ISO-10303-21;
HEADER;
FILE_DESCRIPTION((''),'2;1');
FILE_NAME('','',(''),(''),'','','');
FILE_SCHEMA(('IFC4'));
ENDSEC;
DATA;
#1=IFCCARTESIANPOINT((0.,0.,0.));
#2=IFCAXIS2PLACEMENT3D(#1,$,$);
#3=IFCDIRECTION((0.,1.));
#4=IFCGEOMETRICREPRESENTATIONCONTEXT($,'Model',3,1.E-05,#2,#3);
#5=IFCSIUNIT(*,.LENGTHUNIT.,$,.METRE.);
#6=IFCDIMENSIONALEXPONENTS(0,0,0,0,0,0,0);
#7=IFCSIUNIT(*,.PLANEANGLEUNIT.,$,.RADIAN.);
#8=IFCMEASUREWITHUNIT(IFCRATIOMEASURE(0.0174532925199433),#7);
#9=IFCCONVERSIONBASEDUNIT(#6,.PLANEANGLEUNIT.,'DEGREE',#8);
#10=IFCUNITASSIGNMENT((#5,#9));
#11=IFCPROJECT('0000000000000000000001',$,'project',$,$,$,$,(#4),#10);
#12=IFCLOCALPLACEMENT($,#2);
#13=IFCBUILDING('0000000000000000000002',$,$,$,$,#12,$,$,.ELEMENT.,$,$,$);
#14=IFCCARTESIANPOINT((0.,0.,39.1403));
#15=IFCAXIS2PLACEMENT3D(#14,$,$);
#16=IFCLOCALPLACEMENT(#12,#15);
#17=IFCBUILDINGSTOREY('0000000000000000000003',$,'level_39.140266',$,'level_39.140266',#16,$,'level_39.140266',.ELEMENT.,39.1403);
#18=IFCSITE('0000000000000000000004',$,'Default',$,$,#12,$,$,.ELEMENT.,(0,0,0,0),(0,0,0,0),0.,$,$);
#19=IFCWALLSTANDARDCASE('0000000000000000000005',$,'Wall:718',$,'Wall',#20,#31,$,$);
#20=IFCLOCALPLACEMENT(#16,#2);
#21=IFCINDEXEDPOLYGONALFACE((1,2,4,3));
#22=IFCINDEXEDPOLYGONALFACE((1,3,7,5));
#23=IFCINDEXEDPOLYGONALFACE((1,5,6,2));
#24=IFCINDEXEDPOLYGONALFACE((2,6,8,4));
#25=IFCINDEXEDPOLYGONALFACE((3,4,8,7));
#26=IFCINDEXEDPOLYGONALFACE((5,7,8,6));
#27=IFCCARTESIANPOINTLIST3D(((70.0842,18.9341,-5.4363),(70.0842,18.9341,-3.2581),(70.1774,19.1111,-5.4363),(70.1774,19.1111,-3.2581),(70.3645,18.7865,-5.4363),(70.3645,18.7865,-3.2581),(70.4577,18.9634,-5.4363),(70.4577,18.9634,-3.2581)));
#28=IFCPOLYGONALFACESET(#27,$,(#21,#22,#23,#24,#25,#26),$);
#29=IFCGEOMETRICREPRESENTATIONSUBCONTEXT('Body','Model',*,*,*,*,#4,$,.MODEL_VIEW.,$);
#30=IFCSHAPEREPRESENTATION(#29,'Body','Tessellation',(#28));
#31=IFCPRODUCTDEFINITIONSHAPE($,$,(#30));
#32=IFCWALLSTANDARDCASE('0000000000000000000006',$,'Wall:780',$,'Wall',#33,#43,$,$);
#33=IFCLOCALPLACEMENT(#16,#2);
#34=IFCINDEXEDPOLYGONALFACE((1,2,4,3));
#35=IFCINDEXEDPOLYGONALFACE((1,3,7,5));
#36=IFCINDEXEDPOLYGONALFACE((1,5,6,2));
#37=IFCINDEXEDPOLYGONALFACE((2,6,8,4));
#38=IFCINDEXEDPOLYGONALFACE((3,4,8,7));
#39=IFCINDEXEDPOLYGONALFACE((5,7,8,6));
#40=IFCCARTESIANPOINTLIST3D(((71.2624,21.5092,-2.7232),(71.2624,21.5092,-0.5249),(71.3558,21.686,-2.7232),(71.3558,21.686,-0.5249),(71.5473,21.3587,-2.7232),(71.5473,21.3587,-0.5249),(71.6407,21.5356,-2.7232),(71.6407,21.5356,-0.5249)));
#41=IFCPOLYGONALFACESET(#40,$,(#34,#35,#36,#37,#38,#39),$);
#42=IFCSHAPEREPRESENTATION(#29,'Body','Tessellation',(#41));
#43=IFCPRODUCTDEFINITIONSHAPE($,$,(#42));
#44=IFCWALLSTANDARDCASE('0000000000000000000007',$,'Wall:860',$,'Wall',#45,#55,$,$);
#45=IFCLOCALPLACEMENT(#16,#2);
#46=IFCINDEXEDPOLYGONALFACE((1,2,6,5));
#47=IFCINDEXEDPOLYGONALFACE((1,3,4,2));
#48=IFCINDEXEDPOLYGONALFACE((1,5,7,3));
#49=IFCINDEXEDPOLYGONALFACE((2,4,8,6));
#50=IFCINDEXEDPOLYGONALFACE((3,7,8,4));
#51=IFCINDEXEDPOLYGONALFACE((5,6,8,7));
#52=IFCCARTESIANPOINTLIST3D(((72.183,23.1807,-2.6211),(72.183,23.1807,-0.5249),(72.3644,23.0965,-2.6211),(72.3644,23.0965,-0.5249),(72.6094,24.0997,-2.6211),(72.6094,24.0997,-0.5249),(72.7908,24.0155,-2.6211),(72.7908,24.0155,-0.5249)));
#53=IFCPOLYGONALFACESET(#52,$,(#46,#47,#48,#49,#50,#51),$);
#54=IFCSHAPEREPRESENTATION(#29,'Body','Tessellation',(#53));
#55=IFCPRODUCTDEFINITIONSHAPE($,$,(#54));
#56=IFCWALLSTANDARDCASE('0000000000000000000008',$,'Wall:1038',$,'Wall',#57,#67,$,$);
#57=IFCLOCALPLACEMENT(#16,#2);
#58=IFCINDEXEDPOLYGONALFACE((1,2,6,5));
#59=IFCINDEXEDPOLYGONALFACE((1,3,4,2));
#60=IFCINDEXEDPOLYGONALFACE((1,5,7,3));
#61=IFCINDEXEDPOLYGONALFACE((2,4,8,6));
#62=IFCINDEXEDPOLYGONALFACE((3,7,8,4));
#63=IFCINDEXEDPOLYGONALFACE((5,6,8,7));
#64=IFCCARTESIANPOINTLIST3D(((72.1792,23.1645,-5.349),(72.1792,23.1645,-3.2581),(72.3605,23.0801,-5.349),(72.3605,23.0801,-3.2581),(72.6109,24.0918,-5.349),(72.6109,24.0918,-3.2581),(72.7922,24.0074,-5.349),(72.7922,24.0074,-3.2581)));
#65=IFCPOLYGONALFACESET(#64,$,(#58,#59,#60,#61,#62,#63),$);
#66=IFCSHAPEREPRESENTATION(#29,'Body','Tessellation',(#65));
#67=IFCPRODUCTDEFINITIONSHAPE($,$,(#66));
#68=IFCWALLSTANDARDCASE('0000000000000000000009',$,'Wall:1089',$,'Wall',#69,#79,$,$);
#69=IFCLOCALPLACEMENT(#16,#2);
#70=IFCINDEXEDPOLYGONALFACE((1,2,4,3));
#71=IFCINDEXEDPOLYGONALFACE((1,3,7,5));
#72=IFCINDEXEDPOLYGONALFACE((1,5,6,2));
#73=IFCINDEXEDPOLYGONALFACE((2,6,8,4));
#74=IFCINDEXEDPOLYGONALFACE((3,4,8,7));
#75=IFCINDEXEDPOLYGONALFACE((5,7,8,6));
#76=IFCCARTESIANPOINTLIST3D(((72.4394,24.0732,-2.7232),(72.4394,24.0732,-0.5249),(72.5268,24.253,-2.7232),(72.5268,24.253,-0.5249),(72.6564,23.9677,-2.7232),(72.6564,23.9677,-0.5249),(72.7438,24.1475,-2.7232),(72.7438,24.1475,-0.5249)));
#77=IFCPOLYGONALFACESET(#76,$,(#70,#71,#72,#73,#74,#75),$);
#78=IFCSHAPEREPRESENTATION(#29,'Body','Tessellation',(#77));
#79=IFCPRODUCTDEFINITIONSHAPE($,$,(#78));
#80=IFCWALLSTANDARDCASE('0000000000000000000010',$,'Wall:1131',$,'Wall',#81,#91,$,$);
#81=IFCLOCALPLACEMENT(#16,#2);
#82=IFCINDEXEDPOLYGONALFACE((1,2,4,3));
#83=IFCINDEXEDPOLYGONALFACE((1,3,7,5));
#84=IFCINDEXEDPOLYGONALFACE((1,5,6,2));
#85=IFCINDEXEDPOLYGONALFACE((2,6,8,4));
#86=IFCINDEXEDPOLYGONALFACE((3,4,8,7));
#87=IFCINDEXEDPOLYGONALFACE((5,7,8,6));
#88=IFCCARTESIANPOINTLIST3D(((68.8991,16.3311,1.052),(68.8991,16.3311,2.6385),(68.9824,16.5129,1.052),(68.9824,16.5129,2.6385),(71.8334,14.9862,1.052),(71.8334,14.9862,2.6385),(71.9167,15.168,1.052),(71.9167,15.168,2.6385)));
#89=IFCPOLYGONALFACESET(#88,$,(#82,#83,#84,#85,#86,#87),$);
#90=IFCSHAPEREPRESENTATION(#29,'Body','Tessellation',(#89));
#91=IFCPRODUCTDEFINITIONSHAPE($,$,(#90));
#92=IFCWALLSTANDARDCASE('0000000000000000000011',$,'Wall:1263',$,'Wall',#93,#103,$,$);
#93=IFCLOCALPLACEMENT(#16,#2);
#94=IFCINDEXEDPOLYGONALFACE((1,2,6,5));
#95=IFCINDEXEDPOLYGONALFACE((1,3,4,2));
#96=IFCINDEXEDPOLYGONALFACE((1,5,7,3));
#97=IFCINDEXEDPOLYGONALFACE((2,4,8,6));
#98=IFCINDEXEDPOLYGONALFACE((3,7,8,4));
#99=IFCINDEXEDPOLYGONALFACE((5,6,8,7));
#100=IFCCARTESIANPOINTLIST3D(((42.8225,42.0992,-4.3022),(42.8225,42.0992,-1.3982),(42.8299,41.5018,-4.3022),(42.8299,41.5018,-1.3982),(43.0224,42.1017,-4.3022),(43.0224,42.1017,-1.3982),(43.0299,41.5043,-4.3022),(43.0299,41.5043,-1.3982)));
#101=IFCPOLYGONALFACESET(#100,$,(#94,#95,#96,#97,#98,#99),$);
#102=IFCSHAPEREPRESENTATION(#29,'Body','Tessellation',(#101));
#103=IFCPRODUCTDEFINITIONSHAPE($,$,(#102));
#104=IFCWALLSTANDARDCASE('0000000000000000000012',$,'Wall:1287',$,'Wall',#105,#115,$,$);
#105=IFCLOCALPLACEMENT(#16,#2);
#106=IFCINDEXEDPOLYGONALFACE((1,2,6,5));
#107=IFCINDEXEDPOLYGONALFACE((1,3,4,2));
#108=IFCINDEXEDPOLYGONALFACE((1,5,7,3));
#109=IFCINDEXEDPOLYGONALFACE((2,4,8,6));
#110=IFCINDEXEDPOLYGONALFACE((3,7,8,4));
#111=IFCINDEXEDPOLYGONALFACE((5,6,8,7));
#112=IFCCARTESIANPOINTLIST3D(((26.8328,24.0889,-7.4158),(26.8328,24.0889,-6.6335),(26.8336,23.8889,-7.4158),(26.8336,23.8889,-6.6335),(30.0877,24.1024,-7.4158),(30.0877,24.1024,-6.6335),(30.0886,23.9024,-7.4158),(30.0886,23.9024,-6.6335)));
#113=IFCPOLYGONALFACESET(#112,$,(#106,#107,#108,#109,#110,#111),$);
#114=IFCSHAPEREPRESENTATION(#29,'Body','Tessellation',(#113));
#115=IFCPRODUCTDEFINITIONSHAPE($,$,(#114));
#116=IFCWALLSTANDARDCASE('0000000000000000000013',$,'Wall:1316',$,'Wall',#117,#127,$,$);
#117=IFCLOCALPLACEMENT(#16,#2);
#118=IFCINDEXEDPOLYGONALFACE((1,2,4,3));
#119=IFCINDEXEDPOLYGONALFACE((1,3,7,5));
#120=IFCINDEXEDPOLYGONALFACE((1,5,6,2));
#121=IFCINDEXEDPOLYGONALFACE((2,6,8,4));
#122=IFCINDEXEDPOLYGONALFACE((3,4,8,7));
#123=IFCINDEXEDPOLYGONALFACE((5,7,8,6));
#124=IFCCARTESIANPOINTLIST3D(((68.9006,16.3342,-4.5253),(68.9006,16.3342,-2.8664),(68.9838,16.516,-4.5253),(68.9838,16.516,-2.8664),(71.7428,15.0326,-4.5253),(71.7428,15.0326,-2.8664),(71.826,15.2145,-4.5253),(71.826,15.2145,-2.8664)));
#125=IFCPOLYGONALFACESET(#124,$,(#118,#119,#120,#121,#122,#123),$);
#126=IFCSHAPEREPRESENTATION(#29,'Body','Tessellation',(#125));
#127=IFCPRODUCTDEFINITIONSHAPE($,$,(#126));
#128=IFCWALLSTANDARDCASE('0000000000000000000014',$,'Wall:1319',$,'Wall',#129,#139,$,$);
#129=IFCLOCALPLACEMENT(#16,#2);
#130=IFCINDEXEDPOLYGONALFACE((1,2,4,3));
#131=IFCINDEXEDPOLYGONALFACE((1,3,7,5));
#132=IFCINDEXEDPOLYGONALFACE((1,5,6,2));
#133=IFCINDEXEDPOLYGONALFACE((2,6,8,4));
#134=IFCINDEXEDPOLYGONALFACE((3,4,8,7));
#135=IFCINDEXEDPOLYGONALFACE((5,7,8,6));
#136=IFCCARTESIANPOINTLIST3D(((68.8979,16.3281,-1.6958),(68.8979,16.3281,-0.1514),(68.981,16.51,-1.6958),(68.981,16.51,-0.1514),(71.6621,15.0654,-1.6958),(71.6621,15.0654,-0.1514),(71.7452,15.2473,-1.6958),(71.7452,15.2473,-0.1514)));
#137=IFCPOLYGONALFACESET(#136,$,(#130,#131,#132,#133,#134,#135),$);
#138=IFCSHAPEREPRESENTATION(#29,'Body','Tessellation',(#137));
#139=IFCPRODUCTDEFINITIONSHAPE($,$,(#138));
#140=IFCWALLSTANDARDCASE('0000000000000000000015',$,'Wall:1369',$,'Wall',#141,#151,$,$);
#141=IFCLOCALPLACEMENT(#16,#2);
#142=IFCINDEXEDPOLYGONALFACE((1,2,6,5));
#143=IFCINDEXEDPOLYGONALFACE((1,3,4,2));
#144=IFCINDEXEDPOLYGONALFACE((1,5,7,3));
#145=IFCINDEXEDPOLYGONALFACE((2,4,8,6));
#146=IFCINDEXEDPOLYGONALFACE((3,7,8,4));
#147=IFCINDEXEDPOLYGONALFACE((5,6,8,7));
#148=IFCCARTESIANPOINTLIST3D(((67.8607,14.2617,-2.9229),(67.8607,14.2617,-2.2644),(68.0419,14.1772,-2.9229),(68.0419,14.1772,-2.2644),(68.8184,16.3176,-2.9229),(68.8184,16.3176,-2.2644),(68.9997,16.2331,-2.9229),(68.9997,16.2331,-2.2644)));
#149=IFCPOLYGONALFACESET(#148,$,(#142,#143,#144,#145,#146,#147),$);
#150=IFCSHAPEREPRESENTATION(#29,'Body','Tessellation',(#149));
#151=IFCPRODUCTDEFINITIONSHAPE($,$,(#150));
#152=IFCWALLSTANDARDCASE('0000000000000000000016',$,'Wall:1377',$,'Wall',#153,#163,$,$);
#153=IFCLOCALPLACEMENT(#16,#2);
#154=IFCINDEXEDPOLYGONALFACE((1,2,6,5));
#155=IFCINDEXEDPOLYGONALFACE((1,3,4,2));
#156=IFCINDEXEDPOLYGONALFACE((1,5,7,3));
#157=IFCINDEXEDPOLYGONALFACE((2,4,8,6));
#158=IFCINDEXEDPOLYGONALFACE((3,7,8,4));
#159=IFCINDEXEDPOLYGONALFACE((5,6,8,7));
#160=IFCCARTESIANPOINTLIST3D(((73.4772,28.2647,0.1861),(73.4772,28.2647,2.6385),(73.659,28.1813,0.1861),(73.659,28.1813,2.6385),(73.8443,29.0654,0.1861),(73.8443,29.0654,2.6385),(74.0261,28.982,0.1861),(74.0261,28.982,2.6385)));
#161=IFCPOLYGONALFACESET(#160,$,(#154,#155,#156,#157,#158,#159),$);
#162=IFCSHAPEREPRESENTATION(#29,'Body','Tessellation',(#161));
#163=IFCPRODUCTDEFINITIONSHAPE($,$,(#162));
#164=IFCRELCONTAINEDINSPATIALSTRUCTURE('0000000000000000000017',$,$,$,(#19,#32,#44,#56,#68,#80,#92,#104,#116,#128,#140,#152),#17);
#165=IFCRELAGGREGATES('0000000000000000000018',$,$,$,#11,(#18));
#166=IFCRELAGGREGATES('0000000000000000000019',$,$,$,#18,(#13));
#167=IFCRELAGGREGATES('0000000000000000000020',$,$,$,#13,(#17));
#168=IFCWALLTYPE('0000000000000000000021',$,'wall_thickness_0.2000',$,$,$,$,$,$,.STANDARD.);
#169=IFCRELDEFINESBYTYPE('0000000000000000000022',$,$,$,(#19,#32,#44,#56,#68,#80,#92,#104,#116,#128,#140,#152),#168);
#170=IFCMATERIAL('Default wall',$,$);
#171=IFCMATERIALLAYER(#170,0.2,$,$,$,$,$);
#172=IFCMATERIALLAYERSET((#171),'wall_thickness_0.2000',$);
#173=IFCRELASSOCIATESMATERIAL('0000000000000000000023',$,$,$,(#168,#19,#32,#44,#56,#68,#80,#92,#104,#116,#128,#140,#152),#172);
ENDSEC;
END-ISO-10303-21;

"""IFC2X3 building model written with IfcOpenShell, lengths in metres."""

from ifc_helpers import new_model, entity, si_unit, converted_unit, direction, frame, origin, place, context, subcontext, project, spatial, polyline, outline, extrude, material, layer, layer_set, layer_usage, type_object, element, save


model = new_model("IFC2X3")

# Units and contexts
model_context = context("Model", 3, precision=1e-05, world=origin(), true_north=direction((0.0, 1.0)))
body_context = subcontext(model_context, "Body", "Model", "MODEL_VIEW")
ifc_project = project(units=[si_unit("LENGTHUNIT", "METRE"), converted_unit("PLANEANGLEUNIT", "DEGREE", entity("IfcRatioMeasure", 0.0174532925199433), si_unit("PLANEANGLEUNIT", "RADIAN"), dimensions=[0, 0, 0, 0, 0, 0, 0])], contexts=[model_context])

# Site, building, storey
placement_1 = place(None, origin())
site = spatial("IfcSite", under=ifc_project, at=placement_1, Name="Default", CompositionType="ELEMENT", RefLatitude=(0, 0, 0, 0), RefLongitude=(0, 0, 0, 0), RefElevation=0.0)
building = spatial("IfcBuilding", under=site, at=placement_1, CompositionType="ELEMENT")
storey_placement = place(placement_1, frame((0.0, 0.0, 39.1403)))
storey = spatial("IfcBuildingStorey", under=building, at=storey_placement, Name="level_39.140266", ObjectType="level_39.140266", LongName="level_39.140266", CompositionType="ELEMENT", Elevation=39.1403)

# Shared definitions
ifc_material_1 = material(Name="Default wall")
ifc_layer = layer(ifc_material_1, 0.2)
ifc_layer_set = layer_set([ifc_layer], Name="wall_thickness_0.2000")
ifc_layer_usage = layer_usage(ifc_layer_set, "AXIS2", "POSITIVE", -0.1)
wall_type = type_object("IfcWallType", Name="wall_thickness_0.2000", PredefinedType="STANDARD", material=ifc_layer_set)

# Walls
placement_2 = place(placement_1, frame((0.0, 0.0, 33.704)))
wall_1_placement = place(placement_2, frame((70.4111, 18.8749, 0.0), z_axis=(0.0, 0.0, 1.0), x_axis=(-0.884735, 0.466094, 0.0)))
element("IfcWallStandardCase", 1, at=wall_1_placement, inside=storey, type_object=wall_type, material=ifc_layer_usage, Name="Wall:718", ObjectType="Wall", context=body_context, shape_type="SweptSolid", body=[
    extrude(outline(polyline([(0.3168, -0.1), (0.3168, 0.1), (0.0, 0.1), (0.0, -0.1), (0.3168, -0.1)])), origin(), (0.0, 0.0, 1.0), 2.1782),
])
placement_3 = place(placement_1, frame((0.0, 0.0, 36.4171)))
wall_2_placement = place(placement_3, frame((71.594, 21.4471, 0.0), z_axis=(0.0, 0.0, 1.0), x_axis=(-0.884277, 0.466962, 0.0)))
element("IfcWallStandardCase", 2, at=wall_2_placement, inside=storey, type_object=wall_type, material=ifc_layer_usage, Name="Wall:780", ObjectType="Wall", context=body_context, shape_type="SweptSolid", body=[
    extrude(outline(polyline([(0.3222, -0.1), (0.3222, 0.1), (0.0, 0.1), (0.0, -0.1), (0.3222, -0.1)])), origin(), (0.0, 0.0, 1.0), 2.1982),
])
placement_4 = place(placement_1, frame((0.0, 0.0, 36.5192)))
wall_3_placement = place(placement_4, frame((72.2737, 23.1386, 0.0), z_axis=(0.0, 0.0, 1.0), x_axis=(0.420886, 0.907113, 0.0)))
element("IfcWallStandardCase", 3, at=wall_3_placement, inside=storey, type_object=wall_type, material=ifc_layer_usage, Name="Wall:860", ObjectType="Wall", context=body_context, shape_type="SweptSolid", body=[
    extrude(outline(polyline([(1.0131, -0.1), (1.0131, 0.1), (0.0, 0.1), (0.0, -0.1), (1.0131, -0.1)])), origin(), (0.0, 0.0, 1.0), 2.0962),
])
placement_5 = place(placement_1, frame((0.0, 0.0, 33.7913)))
wall_4_placement = place(placement_5, frame((72.2698, 23.1223, 0.0), z_axis=(0.0, 0.0, 1.0), x_axis=(0.422087, 0.906555, 0.0)))
element("IfcWallStandardCase", 4, at=wall_4_placement, inside=storey, type_object=wall_type, material=ifc_layer_usage, Name="Wall:1038", ObjectType="Wall", context=body_context, shape_type="SweptSolid", body=[
    extrude(outline(polyline([(1.0228, -0.1), (1.0228, 0.1), (0.0, 0.1), (0.0, -0.1), (1.0228, -0.1)])), origin(), (0.0, 0.0, 1.0), 2.0909),
])
placement_6 = place(placement_1, frame((0.0, 0.0, 36.4171)))
wall_5_placement = place(placement_6, frame((72.4831, 24.1631, 0.0), z_axis=(0.0, 0.0, 1.0), x_axis=(0.899371, -0.437187, 0.0)))
element("IfcWallStandardCase", 5, at=wall_5_placement, inside=storey, type_object=wall_type, material=ifc_layer_usage, Name="Wall:1089", ObjectType="Wall", context=body_context, shape_type="SweptSolid", body=[
    extrude(outline(polyline([(0.2413, -0.1), (0.2413, 0.1), (0.0, 0.1), (0.0, -0.1), (0.2413, -0.1)])), origin(), (0.0, 0.0, 1.0), 2.1982),
])
placement_7 = place(placement_1, frame((0.0, 0.0, 40.1923)))
wall_6_placement = place(placement_7, frame((68.9408, 16.422, 0.0), z_axis=(0.0, 0.0, 1.0), x_axis=(0.909056, -0.416674, 0.0)))
element("IfcWallStandardCase", 6, at=wall_6_placement, inside=storey, type_object=wall_type, material=ifc_layer_usage, Name="Wall:1131", ObjectType="Wall", context=body_context, shape_type="SweptSolid", body=[
    extrude(outline(polyline([(3.2278, -0.1), (3.2278, 0.1), (0.0, 0.1), (0.0, -0.1), (3.2278, -0.1)])), origin(), (0.0, 0.0, 1.0), 1.5865),
])
placement_8 = place(placement_1, frame((0.0, 0.0, 34.8381)))
wall_7_placement = place(placement_8, frame((42.9299, 41.5031, 0.0), z_axis=(0.0, 0.0, 1.0), x_axis=(-0.012438, 0.999923, 0.0)))
element("IfcWallStandardCase", 7, at=wall_7_placement, inside=storey, type_object=wall_type, material=ifc_layer_usage, Name="Wall:1263", ObjectType="Wall", context=body_context, shape_type="SweptSolid", body=[
    extrude(outline(polyline([(0.5975, -0.1), (0.5975, 0.1), (0.0, 0.1), (0.0, -0.1), (0.5975, -0.1)])), origin(), (0.0, 0.0, 1.0), 2.9041),
])
placement_9 = place(placement_1, frame((0.0, 0.0, 31.7245)))
wall_8_placement = place(placement_9, frame((26.8332, 23.9889, 0.0), z_axis=(0.0, 0.0, 1.0), x_axis=(0.999991, 0.004162, 0.0)))
element("IfcWallStandardCase", 8, at=wall_8_placement, inside=storey, type_object=wall_type, material=ifc_layer_usage, Name="Wall:1287", ObjectType="Wall", context=body_context, shape_type="SweptSolid", body=[
    extrude(outline(polyline([(3.255, -0.1), (3.255, 0.1), (0.0, 0.1), (0.0, -0.1), (3.255, -0.1)])), origin(), (0.0, 0.0, 1.0), 0.7823),
])
placement_10 = place(placement_1, frame((0.0, 0.0, 34.615)))
wall_9_placement = place(placement_10, frame((68.9422, 16.4251, 0.0), z_axis=(0.0, 0.0, 1.0), x_axis=(0.909202, -0.416354, 0.0)))
element("IfcWallStandardCase", 9, at=wall_9_placement, inside=storey, type_object=wall_type, material=ifc_layer_usage, Name="Wall:1316", ObjectType="Wall", context=body_context, shape_type="SweptSolid", body=[
    extrude(outline(polyline([(3.126, -0.1), (3.126, 0.1), (0.0, 0.1), (0.0, -0.1), (3.126, -0.1)])), origin(), (0.0, 0.0, 1.0), 1.6589),
])
placement_11 = place(placement_1, frame((0.0, 0.0, 37.4445)))
wall_10_placement = place(placement_11, frame((68.9394, 16.4191, 0.0), z_axis=(0.0, 0.0, 1.0), x_axis=(0.909592, -0.415502, 0.0)))
element("IfcWallStandardCase", 10, at=wall_10_placement, inside=storey, type_object=wall_type, material=ifc_layer_usage, Name="Wall:1319", ObjectType="Wall", context=body_context, shape_type="SweptSolid", body=[
    extrude(outline(polyline([(3.039, -0.1), (3.039, 0.1), (0.0, 0.1), (0.0, -0.1), (3.039, -0.1)])), origin(), (0.0, 0.0, 1.0), 1.5443),
])
placement_12 = place(placement_1, frame((0.0, 0.0, 36.2174)))
wall_11_placement = place(placement_12, frame((67.9513, 14.2195, 0.0), z_axis=(0.0, 0.0, 1.0), x_axis=(0.422276, 0.906467, 0.0)))
element("IfcWallStandardCase", 11, at=wall_11_placement, inside=storey, type_object=wall_type, material=ifc_layer_usage, Name="Wall:1369", ObjectType="Wall", context=body_context, shape_type="SweptSolid", body=[
    extrude(outline(polyline([(2.268, -0.1), (2.268, 0.1), (0.0, 0.1), (0.0, -0.1), (2.268, -0.1)])), origin(), (0.0, 0.0, 1.0), 0.6584),
])
placement_13 = place(placement_1, frame((0.0, 0.0, 39.3264)))
wall_12_placement = place(placement_13, frame((73.9352, 29.0237, 0.0), z_axis=(0.0, 0.0, 1.0), x_axis=(-0.416803, -0.908997, 0.0)))
element("IfcWallStandardCase", 12, at=wall_12_placement, inside=storey, type_object=wall_type, material=ifc_layer_usage, Name="Wall:1377", ObjectType="Wall", context=body_context, shape_type="SweptSolid", body=[
    extrude(outline(polyline([(0.8808, -0.1), (0.8808, 0.1), (0.0, 0.1), (0.0, -0.1), (0.8808, -0.1)])), origin(), (0.0, 0.0, 1.0), 2.4523),
])

save(model, "model.ifc")
